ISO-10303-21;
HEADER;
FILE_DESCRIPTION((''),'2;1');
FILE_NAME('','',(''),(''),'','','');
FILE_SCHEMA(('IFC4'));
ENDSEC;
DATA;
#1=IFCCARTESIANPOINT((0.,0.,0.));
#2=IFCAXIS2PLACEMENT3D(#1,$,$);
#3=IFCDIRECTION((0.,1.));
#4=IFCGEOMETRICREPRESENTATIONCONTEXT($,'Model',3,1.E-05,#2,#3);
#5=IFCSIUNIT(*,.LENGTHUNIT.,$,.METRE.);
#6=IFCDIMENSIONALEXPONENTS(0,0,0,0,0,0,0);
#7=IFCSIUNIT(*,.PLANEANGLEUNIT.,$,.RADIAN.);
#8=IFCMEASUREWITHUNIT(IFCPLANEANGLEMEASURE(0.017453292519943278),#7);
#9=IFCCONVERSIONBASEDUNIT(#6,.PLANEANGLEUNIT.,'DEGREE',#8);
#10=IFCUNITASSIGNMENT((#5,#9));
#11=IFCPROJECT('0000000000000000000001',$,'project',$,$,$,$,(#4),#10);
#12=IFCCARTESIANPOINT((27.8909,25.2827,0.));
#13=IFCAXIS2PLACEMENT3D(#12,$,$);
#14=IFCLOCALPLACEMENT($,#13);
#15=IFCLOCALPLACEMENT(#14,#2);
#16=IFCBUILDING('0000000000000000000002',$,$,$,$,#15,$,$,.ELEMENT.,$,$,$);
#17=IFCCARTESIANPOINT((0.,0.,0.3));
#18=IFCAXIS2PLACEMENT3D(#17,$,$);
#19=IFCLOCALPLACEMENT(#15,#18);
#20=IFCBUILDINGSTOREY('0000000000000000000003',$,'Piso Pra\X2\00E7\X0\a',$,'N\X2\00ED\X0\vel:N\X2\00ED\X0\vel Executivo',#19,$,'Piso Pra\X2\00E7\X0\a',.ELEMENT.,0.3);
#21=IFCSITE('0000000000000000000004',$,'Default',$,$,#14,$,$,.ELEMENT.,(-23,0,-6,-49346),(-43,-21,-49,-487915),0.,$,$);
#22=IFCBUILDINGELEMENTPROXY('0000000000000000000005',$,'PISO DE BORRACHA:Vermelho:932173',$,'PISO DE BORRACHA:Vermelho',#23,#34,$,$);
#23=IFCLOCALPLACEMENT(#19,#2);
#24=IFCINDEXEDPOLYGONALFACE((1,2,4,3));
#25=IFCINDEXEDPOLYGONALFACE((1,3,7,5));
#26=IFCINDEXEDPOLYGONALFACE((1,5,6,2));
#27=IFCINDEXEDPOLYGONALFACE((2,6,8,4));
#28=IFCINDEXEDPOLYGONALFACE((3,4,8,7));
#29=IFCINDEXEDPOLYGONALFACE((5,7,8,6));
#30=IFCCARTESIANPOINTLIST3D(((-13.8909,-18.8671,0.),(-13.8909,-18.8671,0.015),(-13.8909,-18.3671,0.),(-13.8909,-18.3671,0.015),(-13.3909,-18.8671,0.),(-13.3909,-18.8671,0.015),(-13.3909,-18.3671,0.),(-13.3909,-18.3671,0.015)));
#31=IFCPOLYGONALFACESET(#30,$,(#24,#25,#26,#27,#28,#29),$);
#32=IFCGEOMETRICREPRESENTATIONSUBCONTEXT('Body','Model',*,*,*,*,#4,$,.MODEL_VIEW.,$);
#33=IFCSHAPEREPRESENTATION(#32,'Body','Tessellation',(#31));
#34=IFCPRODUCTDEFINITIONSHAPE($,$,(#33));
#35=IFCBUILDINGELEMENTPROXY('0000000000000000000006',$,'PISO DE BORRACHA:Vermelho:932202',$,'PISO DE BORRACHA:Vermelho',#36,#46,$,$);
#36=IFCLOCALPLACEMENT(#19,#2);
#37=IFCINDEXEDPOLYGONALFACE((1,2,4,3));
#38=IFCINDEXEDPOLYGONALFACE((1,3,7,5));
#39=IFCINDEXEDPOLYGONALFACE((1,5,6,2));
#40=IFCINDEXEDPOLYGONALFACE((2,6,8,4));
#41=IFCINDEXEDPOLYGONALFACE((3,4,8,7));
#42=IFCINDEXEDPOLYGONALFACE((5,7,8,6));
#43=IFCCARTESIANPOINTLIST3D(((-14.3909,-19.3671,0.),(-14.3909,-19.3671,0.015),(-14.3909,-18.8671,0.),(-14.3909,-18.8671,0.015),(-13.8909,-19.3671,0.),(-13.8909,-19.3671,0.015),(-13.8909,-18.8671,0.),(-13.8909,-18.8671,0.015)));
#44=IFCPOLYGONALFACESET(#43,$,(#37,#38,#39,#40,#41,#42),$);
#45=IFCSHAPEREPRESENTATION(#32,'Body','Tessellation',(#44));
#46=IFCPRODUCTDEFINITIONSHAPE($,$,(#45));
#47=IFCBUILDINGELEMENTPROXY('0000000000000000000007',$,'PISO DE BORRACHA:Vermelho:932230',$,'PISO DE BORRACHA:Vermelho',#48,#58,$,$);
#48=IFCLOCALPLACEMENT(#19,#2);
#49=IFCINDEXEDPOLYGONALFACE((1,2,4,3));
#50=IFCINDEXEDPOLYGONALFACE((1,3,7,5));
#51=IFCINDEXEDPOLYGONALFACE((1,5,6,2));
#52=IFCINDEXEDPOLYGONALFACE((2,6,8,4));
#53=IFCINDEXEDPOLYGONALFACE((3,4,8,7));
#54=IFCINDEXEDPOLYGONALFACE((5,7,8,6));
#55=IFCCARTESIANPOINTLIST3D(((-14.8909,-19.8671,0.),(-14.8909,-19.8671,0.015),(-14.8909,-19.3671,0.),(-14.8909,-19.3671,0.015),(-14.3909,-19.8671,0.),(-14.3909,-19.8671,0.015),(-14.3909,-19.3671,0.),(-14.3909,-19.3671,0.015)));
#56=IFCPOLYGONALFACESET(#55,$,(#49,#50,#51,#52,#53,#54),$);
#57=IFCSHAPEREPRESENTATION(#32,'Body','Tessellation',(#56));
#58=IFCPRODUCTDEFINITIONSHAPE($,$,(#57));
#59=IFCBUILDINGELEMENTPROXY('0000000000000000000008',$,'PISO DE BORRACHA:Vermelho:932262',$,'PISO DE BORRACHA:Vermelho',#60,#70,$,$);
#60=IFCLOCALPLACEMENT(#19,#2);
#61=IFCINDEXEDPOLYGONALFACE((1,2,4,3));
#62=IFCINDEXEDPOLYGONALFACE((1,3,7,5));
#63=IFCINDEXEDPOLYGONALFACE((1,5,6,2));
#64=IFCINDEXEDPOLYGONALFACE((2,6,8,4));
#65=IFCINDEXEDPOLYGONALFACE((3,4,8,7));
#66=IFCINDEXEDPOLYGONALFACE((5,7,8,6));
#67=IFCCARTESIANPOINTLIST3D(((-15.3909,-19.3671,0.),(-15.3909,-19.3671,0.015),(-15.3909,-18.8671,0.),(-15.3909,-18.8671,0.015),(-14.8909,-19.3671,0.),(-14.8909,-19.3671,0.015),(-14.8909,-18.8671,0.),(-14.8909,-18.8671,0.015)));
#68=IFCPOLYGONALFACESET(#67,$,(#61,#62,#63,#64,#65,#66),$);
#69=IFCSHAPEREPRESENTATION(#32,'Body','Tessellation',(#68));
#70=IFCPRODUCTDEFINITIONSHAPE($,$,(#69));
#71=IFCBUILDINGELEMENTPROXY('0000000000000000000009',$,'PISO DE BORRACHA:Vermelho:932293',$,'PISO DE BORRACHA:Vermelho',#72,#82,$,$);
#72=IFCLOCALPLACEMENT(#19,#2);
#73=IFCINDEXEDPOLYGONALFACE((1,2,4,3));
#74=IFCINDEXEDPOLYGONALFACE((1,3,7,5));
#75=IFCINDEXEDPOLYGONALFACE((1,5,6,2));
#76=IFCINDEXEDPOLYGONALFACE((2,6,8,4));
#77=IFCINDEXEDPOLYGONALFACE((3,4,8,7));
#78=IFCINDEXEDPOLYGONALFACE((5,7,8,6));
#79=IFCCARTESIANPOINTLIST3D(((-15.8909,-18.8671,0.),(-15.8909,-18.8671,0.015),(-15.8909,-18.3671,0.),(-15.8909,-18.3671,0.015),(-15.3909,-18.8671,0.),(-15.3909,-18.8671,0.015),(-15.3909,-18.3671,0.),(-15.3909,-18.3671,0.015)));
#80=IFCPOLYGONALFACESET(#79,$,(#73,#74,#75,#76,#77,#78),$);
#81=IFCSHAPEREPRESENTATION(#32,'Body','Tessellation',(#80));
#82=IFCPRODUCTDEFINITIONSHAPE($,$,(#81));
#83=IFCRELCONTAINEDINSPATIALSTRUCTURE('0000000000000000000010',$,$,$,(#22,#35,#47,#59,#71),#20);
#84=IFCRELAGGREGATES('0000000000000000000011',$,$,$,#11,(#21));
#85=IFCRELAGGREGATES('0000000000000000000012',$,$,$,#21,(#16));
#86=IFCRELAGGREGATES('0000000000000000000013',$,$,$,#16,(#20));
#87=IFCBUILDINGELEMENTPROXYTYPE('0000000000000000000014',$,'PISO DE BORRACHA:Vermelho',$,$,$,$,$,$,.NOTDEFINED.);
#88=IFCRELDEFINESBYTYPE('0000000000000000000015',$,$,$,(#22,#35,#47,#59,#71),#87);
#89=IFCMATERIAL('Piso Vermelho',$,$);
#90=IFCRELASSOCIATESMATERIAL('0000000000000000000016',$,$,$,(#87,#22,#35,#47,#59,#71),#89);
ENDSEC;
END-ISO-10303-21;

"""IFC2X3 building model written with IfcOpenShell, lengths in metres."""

from ifc_helpers import new_model, entity, si_unit, converted_unit, direction, frame, origin, origin_2d_with_axis, place, context, subcontext, project, spatial, rectangle, extrude, source, transform, mapped, material, type_object, type_shapes, element, save


model = new_model("IFC2X3")

# Units and contexts
model_context = context("Model", 3, precision=1e-05, world=origin(), true_north=direction((0.0, 1.0)))
body_context = subcontext(model_context, "Body", "Model", "MODEL_VIEW")
ifc_project = project(units=[si_unit("LENGTHUNIT", "METRE"), converted_unit("PLANEANGLEUNIT", "DEGREE", entity("IfcPlaneAngleMeasure", 0.017453292519943278), si_unit("PLANEANGLEUNIT", "RADIAN"), dimensions=[0, 0, 0, 0, 0, 0, 0])], contexts=[model_context])

# Site, building, storey
site_placement = place(None, frame((27.8909, 25.2827, 0.0)))
site = spatial("IfcSite", under=ifc_project, at=site_placement, Name="Default", CompositionType="ELEMENT", RefLatitude=(-23, 0, -6, -49346), RefLongitude=(-43, -21, -49, -487915), RefElevation=0.0)
building_placement = place(site_placement, origin())
building = spatial("IfcBuilding", under=site, at=building_placement, CompositionType="ELEMENT")
storey_placement = place(building_placement, frame((0.0, 0.0, 0.3)))
storey = spatial("IfcBuildingStorey", under=building, at=storey_placement, Name="Piso Praça", ObjectType="Nível:Nível Executivo", LongName="Piso Praça", CompositionType="ELEMENT", Elevation=0.3)

# Building element proxies
ifc_material_1 = material(Name="Piso Vermelho")
building_element_proxy_type_1 = type_object("IfcBuildingElementProxyType", Name="PISO DE BORRACHA:Vermelho", PredefinedType="NOTDEFINED", material=ifc_material_1)
shared_shape_1 = source(origin(), body_context, "Body", "SweptSolid", [
    extrude(rectangle(XDim=0.5, YDim=0.5, at=origin_2d_with_axis()), frame((0.25, 0.25, 0.0), z_axis=(0.0, 0.0, 1.0), x_axis=(-1.0, 0.0, 0.0)), (0.0, 0.0, 1.0), 0.015),
])
type_shapes(building_element_proxy_type_1, [shared_shape_1])
for number, where, z_axis, x_axis, name in (
    (1, (-13.8909, -18.3671, 0.0), (0.0, 0.0, 1.0), (0.0, -1.0, 0.0), "PISO DE BORRACHA:Vermelho:932173"),
    (2, (-14.3909, -18.8671, 0.0), (0.0, 0.0, 1.0), (0.0, -1.0, 0.0), "PISO DE BORRACHA:Vermelho:932202"),
    (3, (-14.8909, -19.3671, 0.0), (0.0, 0.0, 1.0), (0.0, -1.0, 0.0), "PISO DE BORRACHA:Vermelho:932230"),
    (4, (-15.3909, -18.8671, 0.0), (0.0, 0.0, 1.0), (0.0, -1.0, 0.0), "PISO DE BORRACHA:Vermelho:932262"),
    (5, (-15.8909, -18.3671, 0.0), (0.0, 0.0, 1.0), (0.0, -1.0, 0.0), "PISO DE BORRACHA:Vermelho:932293"),
):
    element("IfcBuildingElementProxy", number, at=place(storey_placement, frame(where, z_axis=z_axis, x_axis=x_axis)), inside=storey, type_object=building_element_proxy_type_1, material=ifc_material_1, Name=name, ObjectType="PISO DE BORRACHA:Vermelho", context=body_context, shape_type="MappedRepresentation", body=[
        mapped(shared_shape_1, transform((0.0, 0.0, 0.0), scale=1.0)),
    ])

save(model, "model.ifc")
